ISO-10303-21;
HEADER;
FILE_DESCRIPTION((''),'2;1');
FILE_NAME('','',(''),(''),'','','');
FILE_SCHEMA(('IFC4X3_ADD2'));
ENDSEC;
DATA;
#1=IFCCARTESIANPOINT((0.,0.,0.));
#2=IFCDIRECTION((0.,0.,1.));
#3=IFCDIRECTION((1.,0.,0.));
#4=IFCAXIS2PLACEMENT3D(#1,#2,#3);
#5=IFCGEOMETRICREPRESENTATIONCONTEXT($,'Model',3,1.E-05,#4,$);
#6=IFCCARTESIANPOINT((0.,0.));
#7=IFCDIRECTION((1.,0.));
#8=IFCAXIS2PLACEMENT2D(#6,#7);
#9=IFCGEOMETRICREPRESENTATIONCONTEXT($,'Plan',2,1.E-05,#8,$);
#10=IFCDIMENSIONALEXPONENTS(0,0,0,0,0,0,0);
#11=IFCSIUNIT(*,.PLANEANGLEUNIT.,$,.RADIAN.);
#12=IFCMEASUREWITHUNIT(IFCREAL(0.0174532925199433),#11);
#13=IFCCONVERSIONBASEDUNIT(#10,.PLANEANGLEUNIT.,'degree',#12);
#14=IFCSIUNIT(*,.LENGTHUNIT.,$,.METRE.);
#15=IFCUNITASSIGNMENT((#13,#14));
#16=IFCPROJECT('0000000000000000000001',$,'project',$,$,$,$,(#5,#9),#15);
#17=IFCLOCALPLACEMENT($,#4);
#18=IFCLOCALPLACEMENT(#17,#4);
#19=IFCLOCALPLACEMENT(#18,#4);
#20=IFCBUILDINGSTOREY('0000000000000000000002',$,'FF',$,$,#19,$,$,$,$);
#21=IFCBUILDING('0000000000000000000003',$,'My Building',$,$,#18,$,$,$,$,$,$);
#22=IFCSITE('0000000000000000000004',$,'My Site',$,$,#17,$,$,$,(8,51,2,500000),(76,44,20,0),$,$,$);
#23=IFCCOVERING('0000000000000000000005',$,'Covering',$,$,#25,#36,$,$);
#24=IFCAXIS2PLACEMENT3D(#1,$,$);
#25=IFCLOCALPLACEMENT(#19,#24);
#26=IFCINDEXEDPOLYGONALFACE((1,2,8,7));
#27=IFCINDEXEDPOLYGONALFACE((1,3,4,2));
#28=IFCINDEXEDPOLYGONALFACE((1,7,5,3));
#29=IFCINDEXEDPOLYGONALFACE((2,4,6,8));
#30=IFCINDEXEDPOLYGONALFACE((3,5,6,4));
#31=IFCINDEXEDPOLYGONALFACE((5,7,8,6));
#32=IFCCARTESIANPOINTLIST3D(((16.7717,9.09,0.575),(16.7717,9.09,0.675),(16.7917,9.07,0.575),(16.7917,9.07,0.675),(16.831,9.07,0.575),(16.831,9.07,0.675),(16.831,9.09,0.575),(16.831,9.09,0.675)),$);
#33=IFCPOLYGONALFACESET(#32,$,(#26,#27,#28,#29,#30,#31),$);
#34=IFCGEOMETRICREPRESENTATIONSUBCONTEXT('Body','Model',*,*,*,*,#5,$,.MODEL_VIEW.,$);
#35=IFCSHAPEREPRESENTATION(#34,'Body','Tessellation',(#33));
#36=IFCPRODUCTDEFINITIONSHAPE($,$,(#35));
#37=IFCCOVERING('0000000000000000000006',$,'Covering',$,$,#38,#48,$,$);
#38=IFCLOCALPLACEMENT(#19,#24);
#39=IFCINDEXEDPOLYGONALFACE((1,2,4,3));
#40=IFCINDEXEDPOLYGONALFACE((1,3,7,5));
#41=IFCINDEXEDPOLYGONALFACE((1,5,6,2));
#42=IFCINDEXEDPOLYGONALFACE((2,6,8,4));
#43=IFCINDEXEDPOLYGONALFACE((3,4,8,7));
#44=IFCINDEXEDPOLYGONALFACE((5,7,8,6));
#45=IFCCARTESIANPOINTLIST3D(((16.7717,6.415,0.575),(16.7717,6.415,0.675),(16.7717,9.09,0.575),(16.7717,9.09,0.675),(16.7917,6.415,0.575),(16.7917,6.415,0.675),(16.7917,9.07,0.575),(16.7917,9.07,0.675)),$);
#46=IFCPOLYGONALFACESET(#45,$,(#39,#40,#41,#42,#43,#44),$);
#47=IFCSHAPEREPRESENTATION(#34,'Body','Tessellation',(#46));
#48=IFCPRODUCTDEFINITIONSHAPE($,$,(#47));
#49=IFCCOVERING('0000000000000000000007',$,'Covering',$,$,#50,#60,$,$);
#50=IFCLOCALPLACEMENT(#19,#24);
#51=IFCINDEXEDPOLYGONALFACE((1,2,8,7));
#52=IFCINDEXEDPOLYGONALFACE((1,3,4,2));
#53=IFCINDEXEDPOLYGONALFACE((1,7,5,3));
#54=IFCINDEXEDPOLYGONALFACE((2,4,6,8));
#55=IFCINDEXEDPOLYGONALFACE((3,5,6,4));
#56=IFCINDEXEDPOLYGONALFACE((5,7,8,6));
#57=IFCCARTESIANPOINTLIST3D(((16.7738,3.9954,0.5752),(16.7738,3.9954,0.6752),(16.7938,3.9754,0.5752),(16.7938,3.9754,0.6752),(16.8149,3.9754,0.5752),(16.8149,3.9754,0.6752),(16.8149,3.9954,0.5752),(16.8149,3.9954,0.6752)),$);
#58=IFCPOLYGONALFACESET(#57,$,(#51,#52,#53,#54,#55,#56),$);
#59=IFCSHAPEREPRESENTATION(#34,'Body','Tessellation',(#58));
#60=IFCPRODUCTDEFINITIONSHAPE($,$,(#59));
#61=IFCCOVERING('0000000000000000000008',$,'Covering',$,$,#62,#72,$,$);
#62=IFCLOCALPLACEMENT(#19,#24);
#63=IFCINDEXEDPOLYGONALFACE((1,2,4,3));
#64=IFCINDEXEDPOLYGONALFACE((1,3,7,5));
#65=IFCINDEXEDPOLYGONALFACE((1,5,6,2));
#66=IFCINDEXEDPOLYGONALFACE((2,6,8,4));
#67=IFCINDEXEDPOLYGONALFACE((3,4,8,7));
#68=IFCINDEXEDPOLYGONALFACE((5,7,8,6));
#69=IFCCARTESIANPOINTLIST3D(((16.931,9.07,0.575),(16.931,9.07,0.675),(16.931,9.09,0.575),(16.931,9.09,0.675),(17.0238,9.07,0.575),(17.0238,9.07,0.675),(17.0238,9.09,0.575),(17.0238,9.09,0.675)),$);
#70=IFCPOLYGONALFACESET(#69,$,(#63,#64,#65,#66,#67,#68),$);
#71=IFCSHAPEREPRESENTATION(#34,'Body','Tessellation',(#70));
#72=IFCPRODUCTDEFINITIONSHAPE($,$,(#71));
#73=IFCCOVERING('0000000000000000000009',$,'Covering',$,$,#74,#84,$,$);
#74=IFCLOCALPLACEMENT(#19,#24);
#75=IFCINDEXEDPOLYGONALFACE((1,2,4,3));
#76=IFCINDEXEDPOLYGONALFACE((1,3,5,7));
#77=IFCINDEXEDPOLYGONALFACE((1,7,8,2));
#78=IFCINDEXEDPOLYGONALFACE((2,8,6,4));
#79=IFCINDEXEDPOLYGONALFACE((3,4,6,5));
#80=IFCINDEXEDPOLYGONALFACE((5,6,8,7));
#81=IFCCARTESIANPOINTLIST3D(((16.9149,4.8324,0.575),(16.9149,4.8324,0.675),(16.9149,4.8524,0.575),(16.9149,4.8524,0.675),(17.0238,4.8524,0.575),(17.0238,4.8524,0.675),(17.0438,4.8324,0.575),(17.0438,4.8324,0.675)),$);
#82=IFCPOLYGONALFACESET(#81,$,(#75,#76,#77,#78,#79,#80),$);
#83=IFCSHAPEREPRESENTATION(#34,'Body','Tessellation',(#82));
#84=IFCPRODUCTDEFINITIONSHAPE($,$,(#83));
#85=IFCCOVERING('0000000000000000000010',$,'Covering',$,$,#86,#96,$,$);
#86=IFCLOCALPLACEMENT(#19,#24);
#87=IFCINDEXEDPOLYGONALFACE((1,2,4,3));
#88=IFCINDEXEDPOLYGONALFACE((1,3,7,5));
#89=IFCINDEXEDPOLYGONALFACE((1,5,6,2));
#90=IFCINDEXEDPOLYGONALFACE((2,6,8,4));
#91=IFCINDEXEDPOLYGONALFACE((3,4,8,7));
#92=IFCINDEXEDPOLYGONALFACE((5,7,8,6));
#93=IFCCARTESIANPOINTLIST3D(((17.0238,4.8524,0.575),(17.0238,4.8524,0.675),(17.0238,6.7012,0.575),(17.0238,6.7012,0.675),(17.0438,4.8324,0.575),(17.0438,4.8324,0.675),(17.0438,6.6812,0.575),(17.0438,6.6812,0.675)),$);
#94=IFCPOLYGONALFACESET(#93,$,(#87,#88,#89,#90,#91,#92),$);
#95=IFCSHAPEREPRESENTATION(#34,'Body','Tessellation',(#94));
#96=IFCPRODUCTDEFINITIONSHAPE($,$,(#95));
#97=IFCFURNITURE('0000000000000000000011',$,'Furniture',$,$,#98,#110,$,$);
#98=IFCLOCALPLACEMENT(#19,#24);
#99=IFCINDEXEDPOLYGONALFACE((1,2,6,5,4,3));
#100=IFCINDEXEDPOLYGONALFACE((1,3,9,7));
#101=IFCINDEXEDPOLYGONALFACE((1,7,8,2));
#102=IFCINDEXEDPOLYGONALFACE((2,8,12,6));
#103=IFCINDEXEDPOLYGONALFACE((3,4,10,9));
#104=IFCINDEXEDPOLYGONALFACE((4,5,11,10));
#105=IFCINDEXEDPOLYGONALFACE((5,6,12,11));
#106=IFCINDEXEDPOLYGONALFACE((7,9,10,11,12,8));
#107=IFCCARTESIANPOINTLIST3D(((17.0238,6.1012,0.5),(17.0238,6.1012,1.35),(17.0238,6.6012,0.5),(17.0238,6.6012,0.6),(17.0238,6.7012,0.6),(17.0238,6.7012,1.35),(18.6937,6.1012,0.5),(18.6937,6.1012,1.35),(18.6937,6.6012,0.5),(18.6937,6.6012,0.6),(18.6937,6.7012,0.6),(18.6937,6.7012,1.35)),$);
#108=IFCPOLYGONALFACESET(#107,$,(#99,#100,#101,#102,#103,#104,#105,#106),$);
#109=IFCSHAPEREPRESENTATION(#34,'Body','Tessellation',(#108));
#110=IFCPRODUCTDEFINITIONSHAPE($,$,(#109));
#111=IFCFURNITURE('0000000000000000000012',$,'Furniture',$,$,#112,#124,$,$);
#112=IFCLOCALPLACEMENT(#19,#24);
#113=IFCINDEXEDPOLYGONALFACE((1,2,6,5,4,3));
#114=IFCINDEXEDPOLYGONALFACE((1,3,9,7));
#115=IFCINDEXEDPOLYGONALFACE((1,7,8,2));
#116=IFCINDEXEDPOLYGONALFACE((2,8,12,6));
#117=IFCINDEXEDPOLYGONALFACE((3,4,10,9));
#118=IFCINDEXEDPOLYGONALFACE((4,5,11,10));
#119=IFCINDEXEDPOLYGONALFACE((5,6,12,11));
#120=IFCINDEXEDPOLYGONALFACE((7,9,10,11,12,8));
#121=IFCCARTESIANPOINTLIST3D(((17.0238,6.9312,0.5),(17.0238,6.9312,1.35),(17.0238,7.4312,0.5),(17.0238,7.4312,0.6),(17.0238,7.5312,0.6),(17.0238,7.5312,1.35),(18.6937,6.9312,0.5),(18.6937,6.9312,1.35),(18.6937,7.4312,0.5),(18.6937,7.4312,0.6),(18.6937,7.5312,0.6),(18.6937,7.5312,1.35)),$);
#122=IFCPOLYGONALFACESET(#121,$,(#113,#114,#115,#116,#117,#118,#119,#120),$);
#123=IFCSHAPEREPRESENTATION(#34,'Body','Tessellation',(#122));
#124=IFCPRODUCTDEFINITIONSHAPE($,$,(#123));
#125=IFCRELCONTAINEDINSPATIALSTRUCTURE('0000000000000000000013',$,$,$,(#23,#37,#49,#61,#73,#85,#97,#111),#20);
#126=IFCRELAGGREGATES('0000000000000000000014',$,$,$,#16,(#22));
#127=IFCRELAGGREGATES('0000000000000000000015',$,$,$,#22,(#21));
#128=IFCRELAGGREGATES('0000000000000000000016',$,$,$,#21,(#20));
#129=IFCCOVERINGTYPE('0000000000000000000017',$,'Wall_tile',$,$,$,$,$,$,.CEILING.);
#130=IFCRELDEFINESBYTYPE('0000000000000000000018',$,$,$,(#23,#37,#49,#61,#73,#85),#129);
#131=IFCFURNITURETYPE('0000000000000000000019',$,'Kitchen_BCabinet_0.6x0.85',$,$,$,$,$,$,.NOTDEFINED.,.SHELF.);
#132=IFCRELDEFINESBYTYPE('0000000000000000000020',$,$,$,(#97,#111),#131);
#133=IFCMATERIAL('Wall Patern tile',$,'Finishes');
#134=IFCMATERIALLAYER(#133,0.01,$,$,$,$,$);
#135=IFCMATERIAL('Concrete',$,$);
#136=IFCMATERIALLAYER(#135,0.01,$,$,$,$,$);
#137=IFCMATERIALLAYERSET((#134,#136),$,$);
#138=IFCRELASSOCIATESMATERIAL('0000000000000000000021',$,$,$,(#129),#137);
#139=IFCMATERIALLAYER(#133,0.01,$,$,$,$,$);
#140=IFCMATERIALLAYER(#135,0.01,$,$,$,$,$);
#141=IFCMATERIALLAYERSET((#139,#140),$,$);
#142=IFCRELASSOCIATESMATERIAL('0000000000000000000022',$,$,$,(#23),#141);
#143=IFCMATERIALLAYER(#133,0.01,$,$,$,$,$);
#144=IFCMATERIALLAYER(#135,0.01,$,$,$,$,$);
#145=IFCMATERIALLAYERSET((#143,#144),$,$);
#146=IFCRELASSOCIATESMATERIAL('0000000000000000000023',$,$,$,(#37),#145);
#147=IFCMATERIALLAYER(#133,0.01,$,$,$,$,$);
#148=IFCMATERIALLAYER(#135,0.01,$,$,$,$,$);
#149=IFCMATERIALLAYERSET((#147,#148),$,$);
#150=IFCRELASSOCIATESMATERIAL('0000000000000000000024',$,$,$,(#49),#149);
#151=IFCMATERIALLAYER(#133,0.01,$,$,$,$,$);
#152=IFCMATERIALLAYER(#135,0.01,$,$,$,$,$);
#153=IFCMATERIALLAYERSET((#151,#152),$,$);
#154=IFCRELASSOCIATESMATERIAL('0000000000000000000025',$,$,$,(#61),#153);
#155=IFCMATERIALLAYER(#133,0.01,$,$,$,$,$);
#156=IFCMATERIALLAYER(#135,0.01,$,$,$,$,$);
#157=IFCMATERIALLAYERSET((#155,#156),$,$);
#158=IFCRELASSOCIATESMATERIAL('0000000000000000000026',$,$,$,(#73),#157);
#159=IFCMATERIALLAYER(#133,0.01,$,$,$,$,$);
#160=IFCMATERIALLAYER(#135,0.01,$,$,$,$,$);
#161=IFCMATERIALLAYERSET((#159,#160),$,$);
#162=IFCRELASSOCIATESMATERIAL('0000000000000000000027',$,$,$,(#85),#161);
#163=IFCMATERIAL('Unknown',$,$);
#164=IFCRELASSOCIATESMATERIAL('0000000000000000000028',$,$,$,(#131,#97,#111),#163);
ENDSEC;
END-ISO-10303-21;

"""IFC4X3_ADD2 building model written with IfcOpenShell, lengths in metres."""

from ifc_helpers import new_model, entity, si_unit, converted_unit, frame, origin_with_axes, origin_2d_with_axis, place, context, subcontext, project, spatial, line, indexed_curve, outline, extrude, material, layer, layer_set, layer_usage, material_profile, profile_set, profile_usage, type_object, element, save


model = new_model("IFC4X3_ADD2")

# Units and contexts
model_context = context("Model", 3, precision=1e-05, world=origin_with_axes())
plan_context = context("Plan", 2, precision=1e-05, world=origin_2d_with_axis())
body_context = subcontext(model_context, "Body", "Model", "MODEL_VIEW")
ifc_project = project(units=[converted_unit("PLANEANGLEUNIT", "degree", entity("IfcReal", 0.0174532925199433), si_unit("PLANEANGLEUNIT", "RADIAN"), dimensions=[0, 0, 0, 0, 0, 0, 0]), si_unit("LENGTHUNIT", "METRE")], contexts=[model_context, plan_context])

# Site, building, storey
site_placement = place(None, origin_with_axes())
site = spatial("IfcSite", under=ifc_project, at=site_placement, Name="My Site", RefLatitude=(8, 51, 2, 500000), RefLongitude=(76, 44, 20, 0))
building_placement = place(site_placement, origin_with_axes())
building = spatial("IfcBuilding", under=site, at=building_placement, Name="My Building")
storey_placement = place(building_placement, origin_with_axes())
storey = spatial("IfcBuildingStorey", under=building, at=storey_placement, Name="FF")

# Coverings
ifc_material_1 = material(Name="Concrete")
ifc_material_2 = material(Name="Wall Patern tile", Category="Finishes")
ifc_layer_1 = layer(ifc_material_2, 0.01)
ifc_layer_2 = layer(ifc_material_1, 0.01)
ifc_layer_set_1 = layer_set([ifc_layer_1, ifc_layer_2])
covering_type_1 = type_object("IfcCoveringType", Name="Wall_tile", PredefinedType="CEILING", material=ifc_layer_set_1)
ifc_layer_3 = layer(ifc_material_2, 0.01)
ifc_layer_4 = layer(ifc_material_1, 0.01)
ifc_layer_set_2 = layer_set([ifc_layer_3, ifc_layer_4])
ifc_layer_usage_1 = layer_usage(ifc_layer_set_2, "AXIS2", "NEGATIVE", 0.0)
covering_1_placement = place(storey_placement, frame((16.7717, 9.09, 0.575), z_axis=(0.0, 0.0, 1.0), x_axis=(1.0, 0.0, 0.0)))
element("IfcCovering", 1, at=covering_1_placement, inside=storey, type_object=covering_type_1, material=ifc_layer_usage_1, Name="Covering", context=body_context, shape_type="SweptSolid", body=[
    extrude(outline(indexed_curve([(0.02, -0.02), (0.0, 0.0), (0.0593, 0.0), (0.0593, -0.02)], segments=[line(1, 2, 3, 4, 1)])), origin_with_axes(), (0.0, 0.0, 1.0), 0.1),
])
ifc_layer_5 = layer(ifc_material_2, 0.01)
ifc_layer_6 = layer(ifc_material_1, 0.01)
ifc_layer_set_3 = layer_set([ifc_layer_5, ifc_layer_6])
ifc_layer_usage_2 = layer_usage(ifc_layer_set_3, "AXIS2", "POSITIVE", 0.0)
covering_2_placement = place(storey_placement, frame((16.7717, 9.09, 0.575), z_axis=(0.0, 0.0, 1.0), x_axis=(0.0, -1.0, 0.0)))
element("IfcCovering", 2, at=covering_2_placement, inside=storey, type_object=covering_type_1, material=ifc_layer_usage_2, Name="Covering", context=body_context, shape_type="SweptSolid", body=[
    extrude(outline(indexed_curve([(0.0, 0.0), (0.02, 0.02), (2.675, 0.02), (2.675, 0.0)], segments=[line(1, 2, 3, 4, 1)])), origin_with_axes(), (0.0, 0.0, 1.0), 0.1),
])
ifc_layer_7 = layer(ifc_material_2, 0.01)
ifc_layer_8 = layer(ifc_material_1, 0.01)
ifc_layer_set_4 = layer_set([ifc_layer_7, ifc_layer_8])
ifc_layer_usage_3 = layer_usage(ifc_layer_set_4, "AXIS2", "NEGATIVE", 0.0)
covering_3_placement = place(storey_placement, frame((16.7738, 3.9954, 0.5752), z_axis=(0.0, 0.0, 1.0), x_axis=(1.0, 0.0, 0.0)))
element("IfcCovering", 3, at=covering_3_placement, inside=storey, type_object=covering_type_1, material=ifc_layer_usage_3, Name="Covering", context=body_context, shape_type="SweptSolid", body=[
    extrude(outline(indexed_curve([(0.02, -0.02), (0.0, 0.0), (0.041, 0.0), (0.041, -0.02)], segments=[line(1, 2, 3, 4, 1)])), origin_with_axes(), (0.0, 0.0, 1.0), 0.1),
])
ifc_layer_9 = layer(ifc_material_2, 0.01)
ifc_layer_10 = layer(ifc_material_1, 0.01)
ifc_layer_set_5 = layer_set([ifc_layer_9, ifc_layer_10])
ifc_layer_usage_4 = layer_usage(ifc_layer_set_5, "AXIS2", "POSITIVE", 0.0)
covering_4_placement = place(storey_placement, frame((17.0238, 9.09, 0.575), z_axis=(0.0, 0.0, 1.0), x_axis=(-1.0, 0.0, 0.0)))
element("IfcCovering", 4, at=covering_4_placement, inside=storey, type_object=covering_type_1, material=ifc_layer_usage_4, Name="Covering", context=body_context, shape_type="SweptSolid", body=[
    extrude(outline(indexed_curve([(0.0, 0.0), (0.0, 0.02), (0.0929, 0.02), (0.0929, 0.0)], segments=[line(1, 2, 3, 4, 1)])), origin_with_axes(), (0.0, 0.0, 1.0), 0.1),
])
ifc_layer_11 = layer(ifc_material_2, 0.01)
ifc_layer_12 = layer(ifc_material_1, 0.01)
ifc_layer_set_6 = layer_set([ifc_layer_11, ifc_layer_12])
ifc_layer_usage_5 = layer_usage(ifc_layer_set_6, "AXIS2", "POSITIVE", 0.0)
covering_5_placement = place(storey_placement, frame((16.9149, 4.8324, 0.575), z_axis=(0.0, 0.0, 1.0), x_axis=(1.0, 0.0, 0.0)))
element("IfcCovering", 5, at=covering_5_placement, inside=storey, type_object=covering_type_1, material=ifc_layer_usage_5, Name="Covering", context=body_context, shape_type="SweptSolid", body=[
    extrude(outline(indexed_curve([(0.0, 0.0), (0.0, 0.02), (0.109, 0.02), (0.129, 0.0)], segments=[line(1, 2, 3, 4, 1)])), origin_with_axes(), (0.0, 0.0, 1.0), 0.1),
])
ifc_layer_13 = layer(ifc_material_2, 0.01)
ifc_layer_14 = layer(ifc_material_1, 0.01)
ifc_layer_set_7 = layer_set([ifc_layer_13, ifc_layer_14])
ifc_layer_usage_6 = layer_usage(ifc_layer_set_7, "AXIS2", "NEGATIVE", 0.0)
covering_6_placement = place(storey_placement, frame((17.0438, 6.6812, 0.575), z_axis=(0.0, 0.0, 1.0), x_axis=(0.0, -1.0, 0.0)))
element("IfcCovering", 6, at=covering_6_placement, inside=storey, type_object=covering_type_1, material=ifc_layer_usage_6, Name="Covering", context=body_context, shape_type="SweptSolid", body=[
    extrude(outline(indexed_curve([(-0.02, -0.02), (0.0, 0.0), (1.8487, 0.0), (1.8287, -0.02)], segments=[line(1, 2, 3, 4, 1)])), origin_with_axes(), (0.0, 0.0, 1.0), 0.1),
])

# Furniture
ifc_material_3 = material(Name="Unknown")
ifc_material_profile_1 = material_profile(ifc_material_3, outline(indexed_curve([(0.5, 0.0), (0.0, 0.0), (0.0, 0.85), (0.6, 0.85), (0.6, 0.1), (0.5, 0.1), (0.5, 0.0)])))
ifc_profile_set_1 = profile_set([ifc_material_profile_1], Name="blank")
ifc_profile_usage_1 = profile_usage(ifc_profile_set_1, cardinal=5)
furniture_type = type_object("IfcFurnitureType", Name="Kitchen_BCabinet_0.6x0.85", AssemblyPlace="NOTDEFINED", PredefinedType="SHELF", material=ifc_profile_set_1)
furniture_1_placement = place(storey_placement, frame((17.0238, 6.1012, 0.5), z_axis=(1.0, 0.0, 0.0), x_axis=(0.0, 1.0, 0.0)))
element("IfcFurniture", 7, at=furniture_1_placement, inside=storey, type_object=furniture_type, material=ifc_profile_usage_1, Name="Furniture", context=body_context, shape_type="SweptSolid", body=[
    extrude(outline(indexed_curve([(0.5, 0.0), (0.0, 0.0), (0.0, 0.85), (0.6, 0.85), (0.6, 0.1), (0.5, 0.1), (0.5, 0.0)])), origin_with_axes(), (0.0, 0.0, 1.0), 1.6699),
])
ifc_profile_usage_2 = profile_usage(ifc_profile_set_1, cardinal=5)
furniture_2_placement = place(storey_placement, frame((17.0238, 6.9312, 0.5), z_axis=(1.0, 0.0, 0.0), x_axis=(0.0, 1.0, 0.0)))
element("IfcFurniture", 8, at=furniture_2_placement, inside=storey, type_object=furniture_type, material=ifc_profile_usage_2, Name="Furniture", context=body_context, shape_type="SweptSolid", body=[
    extrude(outline(indexed_curve([(0.5, 0.0), (0.0, 0.0), (0.0, 0.85), (0.6, 0.85), (0.6, 0.1), (0.5, 0.1), (0.5, 0.0)])), origin_with_axes(), (0.0, 0.0, 1.0), 1.6699),
])

save(model, "model.ifc")
